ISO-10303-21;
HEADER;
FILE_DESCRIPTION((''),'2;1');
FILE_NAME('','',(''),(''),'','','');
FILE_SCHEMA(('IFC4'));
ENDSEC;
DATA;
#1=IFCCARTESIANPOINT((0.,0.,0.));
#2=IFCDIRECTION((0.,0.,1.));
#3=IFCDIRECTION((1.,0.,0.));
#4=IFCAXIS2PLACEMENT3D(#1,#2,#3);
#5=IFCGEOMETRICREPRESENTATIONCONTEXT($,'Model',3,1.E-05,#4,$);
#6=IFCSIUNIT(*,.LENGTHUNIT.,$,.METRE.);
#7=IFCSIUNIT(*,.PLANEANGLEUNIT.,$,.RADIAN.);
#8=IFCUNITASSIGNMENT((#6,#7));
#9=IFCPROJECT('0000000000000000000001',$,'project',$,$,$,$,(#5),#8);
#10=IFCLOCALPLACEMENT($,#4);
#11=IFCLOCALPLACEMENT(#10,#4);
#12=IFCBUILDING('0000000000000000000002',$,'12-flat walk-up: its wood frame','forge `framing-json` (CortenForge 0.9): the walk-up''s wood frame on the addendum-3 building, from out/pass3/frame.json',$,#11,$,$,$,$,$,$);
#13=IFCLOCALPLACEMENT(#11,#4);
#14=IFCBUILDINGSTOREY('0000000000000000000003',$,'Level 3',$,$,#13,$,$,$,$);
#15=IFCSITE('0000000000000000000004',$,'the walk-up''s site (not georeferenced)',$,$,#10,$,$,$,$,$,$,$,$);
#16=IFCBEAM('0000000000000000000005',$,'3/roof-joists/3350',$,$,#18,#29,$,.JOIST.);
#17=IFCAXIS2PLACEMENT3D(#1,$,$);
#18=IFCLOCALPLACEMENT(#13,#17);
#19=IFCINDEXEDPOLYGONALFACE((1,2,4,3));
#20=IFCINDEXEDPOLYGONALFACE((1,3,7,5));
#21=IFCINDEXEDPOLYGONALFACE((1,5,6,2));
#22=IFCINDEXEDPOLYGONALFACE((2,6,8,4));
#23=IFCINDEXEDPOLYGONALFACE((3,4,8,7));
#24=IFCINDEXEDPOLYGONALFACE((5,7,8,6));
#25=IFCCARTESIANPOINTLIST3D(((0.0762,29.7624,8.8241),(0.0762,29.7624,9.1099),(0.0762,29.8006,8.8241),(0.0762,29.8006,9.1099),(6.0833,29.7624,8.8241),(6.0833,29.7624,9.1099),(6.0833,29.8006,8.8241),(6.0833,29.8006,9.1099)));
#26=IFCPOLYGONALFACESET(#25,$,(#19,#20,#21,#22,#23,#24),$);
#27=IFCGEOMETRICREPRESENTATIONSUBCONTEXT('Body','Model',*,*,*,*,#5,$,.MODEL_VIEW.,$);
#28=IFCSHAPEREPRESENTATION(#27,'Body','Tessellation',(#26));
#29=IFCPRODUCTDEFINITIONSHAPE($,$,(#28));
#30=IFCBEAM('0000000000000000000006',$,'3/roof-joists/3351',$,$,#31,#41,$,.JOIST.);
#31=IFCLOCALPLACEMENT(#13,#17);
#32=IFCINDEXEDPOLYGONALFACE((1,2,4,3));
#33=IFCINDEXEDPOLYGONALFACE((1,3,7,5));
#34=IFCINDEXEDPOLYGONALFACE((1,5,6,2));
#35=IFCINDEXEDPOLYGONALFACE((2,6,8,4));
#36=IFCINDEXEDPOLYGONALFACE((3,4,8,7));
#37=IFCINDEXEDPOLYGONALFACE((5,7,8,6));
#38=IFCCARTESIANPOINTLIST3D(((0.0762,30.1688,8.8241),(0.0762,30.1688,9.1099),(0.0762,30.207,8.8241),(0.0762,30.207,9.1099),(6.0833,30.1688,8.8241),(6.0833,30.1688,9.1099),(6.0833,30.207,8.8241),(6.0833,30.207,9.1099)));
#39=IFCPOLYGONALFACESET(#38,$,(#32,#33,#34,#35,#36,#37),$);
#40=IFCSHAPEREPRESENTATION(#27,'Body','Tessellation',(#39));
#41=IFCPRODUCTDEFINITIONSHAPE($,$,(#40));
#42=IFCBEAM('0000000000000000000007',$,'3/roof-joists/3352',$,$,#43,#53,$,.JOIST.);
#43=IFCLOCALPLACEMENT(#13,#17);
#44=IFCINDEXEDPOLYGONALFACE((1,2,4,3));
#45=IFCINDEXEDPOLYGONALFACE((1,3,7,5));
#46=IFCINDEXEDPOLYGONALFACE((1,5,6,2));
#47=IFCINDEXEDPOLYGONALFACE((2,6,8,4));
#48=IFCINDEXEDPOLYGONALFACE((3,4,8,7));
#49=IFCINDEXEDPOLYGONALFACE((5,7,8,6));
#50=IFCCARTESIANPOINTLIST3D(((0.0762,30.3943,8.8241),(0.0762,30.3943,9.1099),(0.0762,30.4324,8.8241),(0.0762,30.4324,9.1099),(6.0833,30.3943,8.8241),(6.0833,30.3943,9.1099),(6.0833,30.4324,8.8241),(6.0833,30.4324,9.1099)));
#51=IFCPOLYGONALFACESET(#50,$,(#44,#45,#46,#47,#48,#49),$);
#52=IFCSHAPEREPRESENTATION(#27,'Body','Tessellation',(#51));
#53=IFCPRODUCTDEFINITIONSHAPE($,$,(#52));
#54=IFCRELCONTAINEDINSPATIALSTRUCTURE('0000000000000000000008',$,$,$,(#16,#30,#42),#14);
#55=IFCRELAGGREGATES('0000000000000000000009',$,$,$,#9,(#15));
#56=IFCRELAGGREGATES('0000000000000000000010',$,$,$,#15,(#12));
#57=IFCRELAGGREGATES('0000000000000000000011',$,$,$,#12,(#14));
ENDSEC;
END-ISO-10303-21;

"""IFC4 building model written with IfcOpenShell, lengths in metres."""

from ifc_helpers import new_model, si_unit, frame, frame_2d, origin, origin_with_axes, place, context, subcontext, project, spatial, rectangle, extrude, element, save


model = new_model("IFC4")

# Units and contexts
model_context = context("Model", 3, precision=1e-05, world=origin_with_axes())
body_context = subcontext(model_context, "Body", "Model", "MODEL_VIEW")
ifc_project = project(units=[si_unit("LENGTHUNIT", "METRE"), si_unit("PLANEANGLEUNIT", "RADIAN")], contexts=[model_context])

# Site, building, storey
site_placement = place(None, origin_with_axes())
site = spatial("IfcSite", under=ifc_project, at=site_placement, Name="the walk-up's site (not georeferenced)")
building_placement = place(site_placement, origin_with_axes())
building = spatial("IfcBuilding", under=site, at=building_placement, Name="12-flat walk-up: its wood frame", Description="forge `framing-json` (CortenForge 0.9): the walk-up's wood frame on the addendum-3 building, from out/pass3/frame.json")
storey_placement = place(building_placement, origin_with_axes())
storey = spatial("IfcBuildingStorey", under=building, at=storey_placement, Name="Level 3")

# Beams
for number, where, z_axis, x_axis, name in (
    (1, (0.0762, 29.7625, 8.8241), (0.0, 0.0, 1.0), (1.0, 0.0, 0.0), "3/roof-joists/3350"),
    (2, (0.0762, 30.1688, 8.8241), (0.0, 0.0, 1.0), (1.0, 0.0, 0.0), "3/roof-joists/3351"),
    (3, (0.0762, 30.3943, 8.8241), (0.0, 0.0, 1.0), (1.0, 0.0, 0.0), "3/roof-joists/3352"),
):
    element("IfcBeam", number, at=place(storey_placement, frame(where, z_axis=z_axis, x_axis=x_axis)), inside=storey, Name=name, PredefinedType="JOIST", context=body_context, shape_type="SweptSolid", body=[
        extrude(rectangle(XDim=6.0071, YDim=0.0381, at=frame_2d((3.0036, 0.0191))), origin(), (0.0, 0.0, 1.0), 0.2858),
    ])

save(model, "model.ifc")
